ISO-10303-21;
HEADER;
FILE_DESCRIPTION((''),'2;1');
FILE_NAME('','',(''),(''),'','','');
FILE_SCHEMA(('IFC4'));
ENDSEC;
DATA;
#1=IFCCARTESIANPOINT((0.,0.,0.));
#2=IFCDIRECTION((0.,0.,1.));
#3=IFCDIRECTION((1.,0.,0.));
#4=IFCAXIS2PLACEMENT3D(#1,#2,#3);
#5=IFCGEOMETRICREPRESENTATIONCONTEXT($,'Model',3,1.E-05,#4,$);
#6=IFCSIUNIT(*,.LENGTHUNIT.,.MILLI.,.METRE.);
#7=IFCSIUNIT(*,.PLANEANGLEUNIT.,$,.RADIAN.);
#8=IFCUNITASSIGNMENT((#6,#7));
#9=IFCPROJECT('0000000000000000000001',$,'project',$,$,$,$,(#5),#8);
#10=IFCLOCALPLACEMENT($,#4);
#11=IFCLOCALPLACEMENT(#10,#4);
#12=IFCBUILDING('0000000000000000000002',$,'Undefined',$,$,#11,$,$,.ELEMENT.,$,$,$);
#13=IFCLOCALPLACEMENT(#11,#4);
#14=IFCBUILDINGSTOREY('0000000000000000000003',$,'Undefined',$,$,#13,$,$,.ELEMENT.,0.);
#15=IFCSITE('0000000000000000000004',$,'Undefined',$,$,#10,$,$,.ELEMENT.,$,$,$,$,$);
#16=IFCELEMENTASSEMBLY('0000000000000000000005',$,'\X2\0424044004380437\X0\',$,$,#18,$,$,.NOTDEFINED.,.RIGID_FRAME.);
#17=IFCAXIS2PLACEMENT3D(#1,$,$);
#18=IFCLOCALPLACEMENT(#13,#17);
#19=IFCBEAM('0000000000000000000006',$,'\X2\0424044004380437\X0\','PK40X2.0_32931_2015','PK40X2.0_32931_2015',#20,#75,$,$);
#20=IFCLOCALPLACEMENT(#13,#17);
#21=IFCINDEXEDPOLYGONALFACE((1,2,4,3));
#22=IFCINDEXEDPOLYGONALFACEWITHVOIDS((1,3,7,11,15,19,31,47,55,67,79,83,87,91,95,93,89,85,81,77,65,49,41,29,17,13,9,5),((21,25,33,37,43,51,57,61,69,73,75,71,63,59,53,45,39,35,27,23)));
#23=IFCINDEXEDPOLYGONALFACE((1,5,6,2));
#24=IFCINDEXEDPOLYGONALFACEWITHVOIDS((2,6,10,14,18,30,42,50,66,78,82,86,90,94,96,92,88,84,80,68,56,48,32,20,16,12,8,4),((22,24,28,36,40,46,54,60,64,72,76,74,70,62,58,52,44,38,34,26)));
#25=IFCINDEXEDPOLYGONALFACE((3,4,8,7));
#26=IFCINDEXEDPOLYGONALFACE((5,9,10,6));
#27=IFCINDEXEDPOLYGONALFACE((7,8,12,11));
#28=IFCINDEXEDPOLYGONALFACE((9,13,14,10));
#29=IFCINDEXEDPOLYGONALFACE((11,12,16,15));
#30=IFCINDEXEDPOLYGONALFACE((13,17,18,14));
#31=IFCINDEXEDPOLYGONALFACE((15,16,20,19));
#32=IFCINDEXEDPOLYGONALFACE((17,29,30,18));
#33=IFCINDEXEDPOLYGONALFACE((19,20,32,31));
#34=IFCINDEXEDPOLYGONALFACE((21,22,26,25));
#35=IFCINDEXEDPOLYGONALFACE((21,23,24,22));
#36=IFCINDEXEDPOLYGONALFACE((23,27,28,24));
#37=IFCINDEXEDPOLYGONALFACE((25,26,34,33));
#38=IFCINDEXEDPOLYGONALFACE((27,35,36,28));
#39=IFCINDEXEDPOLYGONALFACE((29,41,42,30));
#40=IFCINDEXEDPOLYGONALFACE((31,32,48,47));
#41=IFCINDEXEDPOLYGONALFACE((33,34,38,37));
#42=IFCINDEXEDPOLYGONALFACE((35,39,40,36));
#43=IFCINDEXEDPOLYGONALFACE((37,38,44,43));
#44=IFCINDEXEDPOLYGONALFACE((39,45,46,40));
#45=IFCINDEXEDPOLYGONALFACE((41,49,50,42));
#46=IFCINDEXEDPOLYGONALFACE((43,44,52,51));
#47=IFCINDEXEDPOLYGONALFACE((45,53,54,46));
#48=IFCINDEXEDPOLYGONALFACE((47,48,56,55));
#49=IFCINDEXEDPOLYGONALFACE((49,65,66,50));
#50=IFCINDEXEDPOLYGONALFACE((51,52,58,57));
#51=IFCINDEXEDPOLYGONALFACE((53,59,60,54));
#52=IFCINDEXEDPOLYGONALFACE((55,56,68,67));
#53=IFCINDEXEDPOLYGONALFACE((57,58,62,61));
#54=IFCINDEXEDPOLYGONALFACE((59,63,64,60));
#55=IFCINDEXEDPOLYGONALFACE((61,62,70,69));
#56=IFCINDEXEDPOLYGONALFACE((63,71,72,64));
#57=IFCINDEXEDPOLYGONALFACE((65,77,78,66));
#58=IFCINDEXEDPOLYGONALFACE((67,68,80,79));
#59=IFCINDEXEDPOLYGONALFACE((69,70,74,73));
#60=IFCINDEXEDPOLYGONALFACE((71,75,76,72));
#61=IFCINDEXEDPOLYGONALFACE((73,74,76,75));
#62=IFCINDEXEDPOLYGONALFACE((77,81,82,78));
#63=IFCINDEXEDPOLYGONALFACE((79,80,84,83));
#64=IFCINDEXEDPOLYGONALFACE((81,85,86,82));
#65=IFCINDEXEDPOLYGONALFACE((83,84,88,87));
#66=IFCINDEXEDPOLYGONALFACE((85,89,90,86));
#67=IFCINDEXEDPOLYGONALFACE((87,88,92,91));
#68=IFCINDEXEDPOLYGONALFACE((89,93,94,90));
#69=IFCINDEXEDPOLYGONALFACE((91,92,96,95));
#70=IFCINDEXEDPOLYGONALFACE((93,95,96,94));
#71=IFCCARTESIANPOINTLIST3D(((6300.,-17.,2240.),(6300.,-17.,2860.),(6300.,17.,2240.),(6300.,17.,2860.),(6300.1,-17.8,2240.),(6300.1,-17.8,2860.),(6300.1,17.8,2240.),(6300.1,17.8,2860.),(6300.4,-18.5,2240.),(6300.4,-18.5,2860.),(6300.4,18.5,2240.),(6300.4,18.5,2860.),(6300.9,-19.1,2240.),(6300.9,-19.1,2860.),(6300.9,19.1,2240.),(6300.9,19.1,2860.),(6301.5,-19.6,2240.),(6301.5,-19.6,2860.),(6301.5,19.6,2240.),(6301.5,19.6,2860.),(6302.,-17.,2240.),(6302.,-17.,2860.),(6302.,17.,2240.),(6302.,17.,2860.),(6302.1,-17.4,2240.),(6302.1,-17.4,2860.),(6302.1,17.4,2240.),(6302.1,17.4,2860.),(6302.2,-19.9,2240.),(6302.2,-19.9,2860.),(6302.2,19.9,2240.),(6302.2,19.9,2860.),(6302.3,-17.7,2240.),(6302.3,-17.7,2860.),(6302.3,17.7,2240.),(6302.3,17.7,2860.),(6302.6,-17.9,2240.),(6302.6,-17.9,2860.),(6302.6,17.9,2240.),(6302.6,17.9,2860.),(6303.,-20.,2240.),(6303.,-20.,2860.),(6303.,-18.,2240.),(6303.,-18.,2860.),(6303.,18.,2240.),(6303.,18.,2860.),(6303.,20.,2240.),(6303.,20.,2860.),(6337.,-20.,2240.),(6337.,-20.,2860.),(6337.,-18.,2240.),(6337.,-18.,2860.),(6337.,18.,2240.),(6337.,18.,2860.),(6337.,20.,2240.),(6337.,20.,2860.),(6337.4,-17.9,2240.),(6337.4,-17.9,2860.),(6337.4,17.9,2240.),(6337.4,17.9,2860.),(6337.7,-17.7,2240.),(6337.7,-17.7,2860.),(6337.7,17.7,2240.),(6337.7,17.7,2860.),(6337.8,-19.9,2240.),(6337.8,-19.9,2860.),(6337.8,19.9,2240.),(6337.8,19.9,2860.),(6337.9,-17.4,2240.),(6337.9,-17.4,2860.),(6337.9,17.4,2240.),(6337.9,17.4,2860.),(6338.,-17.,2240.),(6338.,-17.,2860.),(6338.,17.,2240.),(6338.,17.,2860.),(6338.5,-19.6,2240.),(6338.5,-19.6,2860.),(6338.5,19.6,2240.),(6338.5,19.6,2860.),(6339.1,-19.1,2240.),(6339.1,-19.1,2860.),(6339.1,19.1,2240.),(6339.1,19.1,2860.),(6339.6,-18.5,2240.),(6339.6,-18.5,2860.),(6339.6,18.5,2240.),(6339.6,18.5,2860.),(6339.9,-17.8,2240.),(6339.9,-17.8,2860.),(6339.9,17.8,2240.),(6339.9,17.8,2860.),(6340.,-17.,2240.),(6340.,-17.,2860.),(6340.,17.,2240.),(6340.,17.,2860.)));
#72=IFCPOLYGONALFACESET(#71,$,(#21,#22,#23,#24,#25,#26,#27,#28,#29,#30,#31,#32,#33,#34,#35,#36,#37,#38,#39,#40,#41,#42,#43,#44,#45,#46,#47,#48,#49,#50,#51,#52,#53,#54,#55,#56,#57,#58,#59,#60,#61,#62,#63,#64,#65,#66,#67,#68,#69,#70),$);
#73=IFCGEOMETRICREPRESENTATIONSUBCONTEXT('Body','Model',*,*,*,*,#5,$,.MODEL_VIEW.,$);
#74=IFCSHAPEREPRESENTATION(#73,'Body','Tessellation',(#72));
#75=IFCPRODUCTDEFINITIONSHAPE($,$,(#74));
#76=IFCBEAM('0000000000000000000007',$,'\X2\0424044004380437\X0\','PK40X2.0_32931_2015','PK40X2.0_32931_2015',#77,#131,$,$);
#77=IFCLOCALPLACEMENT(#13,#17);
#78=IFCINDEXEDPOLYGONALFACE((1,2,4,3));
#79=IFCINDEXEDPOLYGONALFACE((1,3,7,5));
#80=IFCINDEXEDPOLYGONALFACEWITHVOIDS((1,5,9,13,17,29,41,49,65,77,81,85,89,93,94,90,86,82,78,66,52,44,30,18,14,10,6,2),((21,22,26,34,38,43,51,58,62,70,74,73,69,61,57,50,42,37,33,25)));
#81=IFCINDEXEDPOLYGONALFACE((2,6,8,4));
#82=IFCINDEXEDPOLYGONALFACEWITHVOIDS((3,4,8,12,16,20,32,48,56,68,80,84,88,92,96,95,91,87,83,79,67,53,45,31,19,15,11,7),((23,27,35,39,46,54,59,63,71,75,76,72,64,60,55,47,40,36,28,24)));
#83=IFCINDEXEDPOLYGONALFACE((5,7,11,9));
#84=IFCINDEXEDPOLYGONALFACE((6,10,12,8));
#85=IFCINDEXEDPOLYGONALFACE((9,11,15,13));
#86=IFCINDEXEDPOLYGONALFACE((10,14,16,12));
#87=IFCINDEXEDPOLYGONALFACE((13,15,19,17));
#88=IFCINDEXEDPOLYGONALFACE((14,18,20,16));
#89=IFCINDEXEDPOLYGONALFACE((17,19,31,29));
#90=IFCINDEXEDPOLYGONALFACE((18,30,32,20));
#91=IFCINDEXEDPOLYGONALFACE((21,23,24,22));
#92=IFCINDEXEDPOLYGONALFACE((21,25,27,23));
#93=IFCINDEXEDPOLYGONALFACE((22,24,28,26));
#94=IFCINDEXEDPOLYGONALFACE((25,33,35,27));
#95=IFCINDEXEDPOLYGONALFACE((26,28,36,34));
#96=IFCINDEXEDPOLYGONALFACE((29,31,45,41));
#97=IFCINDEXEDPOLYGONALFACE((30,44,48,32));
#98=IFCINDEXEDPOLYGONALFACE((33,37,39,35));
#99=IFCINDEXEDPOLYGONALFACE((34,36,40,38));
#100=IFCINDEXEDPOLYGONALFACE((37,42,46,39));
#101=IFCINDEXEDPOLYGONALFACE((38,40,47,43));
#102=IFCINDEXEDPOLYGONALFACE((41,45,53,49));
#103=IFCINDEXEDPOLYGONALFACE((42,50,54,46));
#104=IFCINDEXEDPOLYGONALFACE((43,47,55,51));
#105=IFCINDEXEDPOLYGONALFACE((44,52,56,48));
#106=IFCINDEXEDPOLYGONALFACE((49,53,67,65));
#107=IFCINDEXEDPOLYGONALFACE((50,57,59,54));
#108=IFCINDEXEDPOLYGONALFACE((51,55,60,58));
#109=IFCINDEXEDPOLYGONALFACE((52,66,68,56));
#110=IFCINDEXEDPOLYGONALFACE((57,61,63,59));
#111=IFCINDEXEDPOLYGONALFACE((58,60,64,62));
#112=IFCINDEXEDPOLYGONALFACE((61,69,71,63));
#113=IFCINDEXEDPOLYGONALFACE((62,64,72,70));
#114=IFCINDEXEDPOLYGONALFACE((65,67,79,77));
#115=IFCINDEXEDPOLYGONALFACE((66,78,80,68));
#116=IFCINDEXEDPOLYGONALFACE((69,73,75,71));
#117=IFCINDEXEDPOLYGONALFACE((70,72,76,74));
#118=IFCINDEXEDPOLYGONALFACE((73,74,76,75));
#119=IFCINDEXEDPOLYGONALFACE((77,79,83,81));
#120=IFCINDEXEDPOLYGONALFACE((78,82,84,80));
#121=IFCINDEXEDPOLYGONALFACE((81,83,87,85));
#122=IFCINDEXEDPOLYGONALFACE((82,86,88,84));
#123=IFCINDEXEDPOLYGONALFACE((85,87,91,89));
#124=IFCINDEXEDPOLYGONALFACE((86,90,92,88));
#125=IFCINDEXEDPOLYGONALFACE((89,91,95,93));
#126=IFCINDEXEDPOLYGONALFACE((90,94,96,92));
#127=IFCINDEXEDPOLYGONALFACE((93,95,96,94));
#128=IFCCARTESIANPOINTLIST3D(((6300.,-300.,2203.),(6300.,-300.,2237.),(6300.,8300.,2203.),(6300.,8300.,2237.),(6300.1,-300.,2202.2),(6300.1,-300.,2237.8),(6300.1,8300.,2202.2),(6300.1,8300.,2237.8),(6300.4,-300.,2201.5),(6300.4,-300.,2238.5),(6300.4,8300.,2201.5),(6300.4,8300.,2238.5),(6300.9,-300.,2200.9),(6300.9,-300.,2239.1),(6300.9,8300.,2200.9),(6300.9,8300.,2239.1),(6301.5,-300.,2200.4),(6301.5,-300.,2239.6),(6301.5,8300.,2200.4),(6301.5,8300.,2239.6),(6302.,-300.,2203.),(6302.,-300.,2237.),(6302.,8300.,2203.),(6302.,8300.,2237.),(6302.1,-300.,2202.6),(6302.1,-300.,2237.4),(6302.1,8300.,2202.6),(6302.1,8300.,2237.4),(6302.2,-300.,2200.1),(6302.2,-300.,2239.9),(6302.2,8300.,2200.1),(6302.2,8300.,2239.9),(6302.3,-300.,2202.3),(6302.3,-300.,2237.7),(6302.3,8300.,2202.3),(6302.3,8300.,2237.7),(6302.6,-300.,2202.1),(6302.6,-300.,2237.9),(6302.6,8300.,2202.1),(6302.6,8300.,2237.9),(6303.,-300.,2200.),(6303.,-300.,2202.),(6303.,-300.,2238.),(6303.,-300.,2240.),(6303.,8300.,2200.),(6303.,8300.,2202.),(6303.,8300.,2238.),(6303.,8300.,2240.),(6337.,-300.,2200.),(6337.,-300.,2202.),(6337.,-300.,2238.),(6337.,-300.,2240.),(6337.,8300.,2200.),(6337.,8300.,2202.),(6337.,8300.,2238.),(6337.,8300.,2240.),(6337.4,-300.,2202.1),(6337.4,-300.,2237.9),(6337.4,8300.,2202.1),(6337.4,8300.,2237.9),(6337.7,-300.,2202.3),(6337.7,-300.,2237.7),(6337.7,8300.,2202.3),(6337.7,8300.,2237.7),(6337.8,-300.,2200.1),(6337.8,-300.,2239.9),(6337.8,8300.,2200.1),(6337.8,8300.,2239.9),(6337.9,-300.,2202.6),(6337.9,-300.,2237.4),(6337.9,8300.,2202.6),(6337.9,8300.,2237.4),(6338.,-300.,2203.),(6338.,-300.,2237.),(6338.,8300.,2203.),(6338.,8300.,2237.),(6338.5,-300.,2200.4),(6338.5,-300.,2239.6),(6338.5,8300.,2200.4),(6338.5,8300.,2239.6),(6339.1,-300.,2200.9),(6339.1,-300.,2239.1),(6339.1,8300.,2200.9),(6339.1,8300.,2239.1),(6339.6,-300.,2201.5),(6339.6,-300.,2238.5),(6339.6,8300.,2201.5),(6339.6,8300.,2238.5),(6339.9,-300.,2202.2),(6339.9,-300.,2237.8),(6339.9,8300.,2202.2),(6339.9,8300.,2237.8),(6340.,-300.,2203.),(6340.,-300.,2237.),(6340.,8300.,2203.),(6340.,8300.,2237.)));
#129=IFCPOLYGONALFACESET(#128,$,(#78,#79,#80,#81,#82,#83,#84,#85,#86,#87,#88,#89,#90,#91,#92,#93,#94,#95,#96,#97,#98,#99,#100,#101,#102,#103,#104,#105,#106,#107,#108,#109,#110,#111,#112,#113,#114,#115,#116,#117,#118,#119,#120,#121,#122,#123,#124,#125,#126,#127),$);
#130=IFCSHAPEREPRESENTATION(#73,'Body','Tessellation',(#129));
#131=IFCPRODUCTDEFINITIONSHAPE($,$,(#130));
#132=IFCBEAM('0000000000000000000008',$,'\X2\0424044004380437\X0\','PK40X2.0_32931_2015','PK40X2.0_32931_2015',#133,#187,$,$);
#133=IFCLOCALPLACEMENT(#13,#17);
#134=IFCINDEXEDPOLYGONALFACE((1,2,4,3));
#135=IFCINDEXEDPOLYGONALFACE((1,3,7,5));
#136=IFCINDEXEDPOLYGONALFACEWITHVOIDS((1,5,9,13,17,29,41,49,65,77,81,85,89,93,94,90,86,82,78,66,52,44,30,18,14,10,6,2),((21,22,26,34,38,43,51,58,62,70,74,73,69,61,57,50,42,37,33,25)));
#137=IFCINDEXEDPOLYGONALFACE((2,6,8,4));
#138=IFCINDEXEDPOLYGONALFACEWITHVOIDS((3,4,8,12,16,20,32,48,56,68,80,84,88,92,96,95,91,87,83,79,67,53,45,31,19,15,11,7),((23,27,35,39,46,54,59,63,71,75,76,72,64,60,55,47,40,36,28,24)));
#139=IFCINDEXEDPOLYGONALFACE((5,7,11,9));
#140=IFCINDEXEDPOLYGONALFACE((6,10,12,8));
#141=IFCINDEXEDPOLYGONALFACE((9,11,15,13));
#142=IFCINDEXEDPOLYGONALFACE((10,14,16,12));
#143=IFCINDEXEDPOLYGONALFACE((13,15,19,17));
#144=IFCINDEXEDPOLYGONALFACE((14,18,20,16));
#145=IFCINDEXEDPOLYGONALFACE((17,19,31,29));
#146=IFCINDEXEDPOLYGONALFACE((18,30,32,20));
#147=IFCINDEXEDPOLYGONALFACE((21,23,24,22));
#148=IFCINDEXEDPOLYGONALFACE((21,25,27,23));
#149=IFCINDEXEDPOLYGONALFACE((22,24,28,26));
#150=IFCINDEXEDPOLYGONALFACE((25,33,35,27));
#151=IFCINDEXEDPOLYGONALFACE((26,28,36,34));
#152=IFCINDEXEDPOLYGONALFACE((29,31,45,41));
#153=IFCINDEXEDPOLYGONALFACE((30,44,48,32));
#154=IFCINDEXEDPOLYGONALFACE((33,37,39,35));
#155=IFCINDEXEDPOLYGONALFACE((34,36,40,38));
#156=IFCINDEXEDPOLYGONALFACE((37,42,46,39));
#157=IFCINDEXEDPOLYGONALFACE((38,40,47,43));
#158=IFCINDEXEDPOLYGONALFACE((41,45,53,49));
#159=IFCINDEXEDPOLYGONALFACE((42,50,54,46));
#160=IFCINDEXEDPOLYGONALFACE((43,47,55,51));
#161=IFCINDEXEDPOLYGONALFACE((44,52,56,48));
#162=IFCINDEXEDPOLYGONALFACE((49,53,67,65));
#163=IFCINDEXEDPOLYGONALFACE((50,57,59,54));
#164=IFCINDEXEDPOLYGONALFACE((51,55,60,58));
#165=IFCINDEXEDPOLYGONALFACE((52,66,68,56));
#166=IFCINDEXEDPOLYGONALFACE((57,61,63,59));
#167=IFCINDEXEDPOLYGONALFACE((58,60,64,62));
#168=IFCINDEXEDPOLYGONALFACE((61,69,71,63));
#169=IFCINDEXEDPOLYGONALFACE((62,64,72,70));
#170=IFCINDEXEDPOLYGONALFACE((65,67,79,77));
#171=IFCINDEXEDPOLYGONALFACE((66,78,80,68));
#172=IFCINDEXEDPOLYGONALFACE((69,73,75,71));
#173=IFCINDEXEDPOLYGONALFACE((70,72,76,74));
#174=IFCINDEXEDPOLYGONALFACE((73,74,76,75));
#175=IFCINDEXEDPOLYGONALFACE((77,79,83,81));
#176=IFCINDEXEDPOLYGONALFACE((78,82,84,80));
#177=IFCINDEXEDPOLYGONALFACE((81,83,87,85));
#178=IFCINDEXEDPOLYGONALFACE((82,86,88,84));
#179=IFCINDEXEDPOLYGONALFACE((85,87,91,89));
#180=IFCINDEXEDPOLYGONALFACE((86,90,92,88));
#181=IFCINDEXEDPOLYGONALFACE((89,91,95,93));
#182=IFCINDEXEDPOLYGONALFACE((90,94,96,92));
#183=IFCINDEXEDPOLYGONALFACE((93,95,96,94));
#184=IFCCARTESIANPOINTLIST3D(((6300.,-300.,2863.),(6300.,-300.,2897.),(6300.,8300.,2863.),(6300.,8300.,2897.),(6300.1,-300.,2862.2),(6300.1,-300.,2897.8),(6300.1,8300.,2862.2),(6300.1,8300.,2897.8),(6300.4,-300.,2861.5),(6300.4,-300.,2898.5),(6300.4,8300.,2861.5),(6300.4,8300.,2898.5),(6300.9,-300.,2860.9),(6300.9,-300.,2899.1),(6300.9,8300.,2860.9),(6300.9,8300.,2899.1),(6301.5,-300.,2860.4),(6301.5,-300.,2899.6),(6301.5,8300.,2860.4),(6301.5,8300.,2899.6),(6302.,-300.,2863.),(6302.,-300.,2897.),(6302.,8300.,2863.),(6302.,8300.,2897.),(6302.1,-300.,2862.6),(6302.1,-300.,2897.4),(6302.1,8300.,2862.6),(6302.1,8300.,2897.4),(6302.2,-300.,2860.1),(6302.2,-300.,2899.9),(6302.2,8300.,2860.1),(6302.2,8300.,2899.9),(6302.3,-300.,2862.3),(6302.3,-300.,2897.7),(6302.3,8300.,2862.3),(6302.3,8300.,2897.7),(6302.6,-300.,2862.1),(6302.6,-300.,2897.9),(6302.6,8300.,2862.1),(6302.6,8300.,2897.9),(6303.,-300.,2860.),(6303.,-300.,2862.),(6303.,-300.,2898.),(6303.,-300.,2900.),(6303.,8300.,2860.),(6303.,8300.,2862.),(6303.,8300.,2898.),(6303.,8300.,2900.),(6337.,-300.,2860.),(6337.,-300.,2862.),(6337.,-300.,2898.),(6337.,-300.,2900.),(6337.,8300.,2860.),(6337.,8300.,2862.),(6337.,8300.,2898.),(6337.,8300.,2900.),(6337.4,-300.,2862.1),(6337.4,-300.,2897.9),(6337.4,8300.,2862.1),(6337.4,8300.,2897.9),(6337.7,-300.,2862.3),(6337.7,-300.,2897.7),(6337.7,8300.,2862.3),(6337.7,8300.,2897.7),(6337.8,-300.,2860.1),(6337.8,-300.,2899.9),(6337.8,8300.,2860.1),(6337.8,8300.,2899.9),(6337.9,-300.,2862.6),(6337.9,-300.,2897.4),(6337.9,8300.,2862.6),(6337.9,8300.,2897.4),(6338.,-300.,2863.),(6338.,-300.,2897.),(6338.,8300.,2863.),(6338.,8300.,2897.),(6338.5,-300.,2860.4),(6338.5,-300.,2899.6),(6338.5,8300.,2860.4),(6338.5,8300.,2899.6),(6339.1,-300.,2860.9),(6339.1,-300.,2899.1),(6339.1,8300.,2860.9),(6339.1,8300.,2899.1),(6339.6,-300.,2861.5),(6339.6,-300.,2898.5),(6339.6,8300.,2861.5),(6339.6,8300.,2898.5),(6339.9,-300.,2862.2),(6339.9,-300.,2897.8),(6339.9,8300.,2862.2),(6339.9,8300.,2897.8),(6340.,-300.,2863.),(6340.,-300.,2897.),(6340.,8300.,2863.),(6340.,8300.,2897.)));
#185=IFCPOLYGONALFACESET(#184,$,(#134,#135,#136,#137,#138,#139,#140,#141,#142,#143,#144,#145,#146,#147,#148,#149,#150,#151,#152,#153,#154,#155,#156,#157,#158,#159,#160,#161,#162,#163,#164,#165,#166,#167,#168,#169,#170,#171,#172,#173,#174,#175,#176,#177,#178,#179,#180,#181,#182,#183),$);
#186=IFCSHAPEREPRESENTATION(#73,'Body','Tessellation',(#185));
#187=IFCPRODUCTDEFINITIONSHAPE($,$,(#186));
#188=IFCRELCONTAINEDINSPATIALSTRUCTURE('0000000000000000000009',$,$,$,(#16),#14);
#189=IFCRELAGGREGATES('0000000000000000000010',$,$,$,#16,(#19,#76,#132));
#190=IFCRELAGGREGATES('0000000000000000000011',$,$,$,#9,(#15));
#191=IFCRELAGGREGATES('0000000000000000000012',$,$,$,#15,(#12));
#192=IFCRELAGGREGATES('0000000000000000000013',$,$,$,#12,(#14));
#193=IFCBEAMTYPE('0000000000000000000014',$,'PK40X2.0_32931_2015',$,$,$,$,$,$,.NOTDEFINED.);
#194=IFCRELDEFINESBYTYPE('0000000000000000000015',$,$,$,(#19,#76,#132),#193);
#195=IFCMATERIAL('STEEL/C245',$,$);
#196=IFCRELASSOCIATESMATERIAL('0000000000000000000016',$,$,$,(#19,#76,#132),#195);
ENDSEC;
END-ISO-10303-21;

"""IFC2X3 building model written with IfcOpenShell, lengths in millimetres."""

from ifc_helpers import new_model, si_unit, frame, origin_with_axes, origin_2d_with_axis, place, context, subcontext, project, spatial, hollow_rectangle, extrude, material, type_object, element, aggregate, save


model = new_model("IFC2X3")

# Units and contexts
model_context = context("Model", 3, precision=1e-05, world=origin_with_axes())
body_context = subcontext(model_context, "Body", "Model", "MODEL_VIEW")
ifc_project = project(units=[si_unit("LENGTHUNIT", "METRE", prefix="MILLI"), si_unit("PLANEANGLEUNIT", "RADIAN")], contexts=[model_context])

# Site, building, storey
site_placement = place(None, origin_with_axes())
site = spatial("IfcSite", under=ifc_project, at=site_placement, Name="Undefined", CompositionType="ELEMENT")
building_placement = place(site_placement, origin_with_axes())
building = spatial("IfcBuilding", under=site, at=building_placement, Name="Undefined", CompositionType="ELEMENT")
storey_placement = place(building_placement, origin_with_axes())
storey = spatial("IfcBuildingStorey", under=building, at=storey_placement, Name="Undefined", CompositionType="ELEMENT", Elevation=0.0)

# Shared definitions
ifc_material_1 = material(Name="STEEL/C245")

# Shared definitions
beam_type_1 = type_object("IfcBeamType", Name="PK40X2.0_32931_2015", PredefinedType="NOTDEFINED")

# Element assembly, beams
assembly_1_placement = place(storey_placement, origin_with_axes())
assembly_1 = element("IfcElementAssembly", 1, at=assembly_1_placement, inside=storey, Name="Фриз", AssemblyPlace="NOTDEFINED", PredefinedType="RIGID_FRAME")
beam_1_placement = place(assembly_1_placement, frame((6320.0, 0.0, 2860.0), z_axis=(-1.0, 0.0, 0.0), x_axis=(0.0, 0.0, -1.0)))
beam_1 = element("IfcBeam", 2, at=beam_1_placement, type_object=beam_type_1, material=ifc_material_1, Name="Фриз", Description="PK40X2.0_32931_2015", ObjectType="PK40X2.0_32931_2015", context=body_context, shape_type="SweptSolid", body=[
    extrude(hollow_rectangle(XDim=40.0, YDim=40.0, WallThickness=2.0, InnerFilletRadius=1.0, OuterFilletRadius=3.0, at=origin_2d_with_axis()), frame((620.0, 0.0, 0.0), z_axis=(-1.0, 0.0, 0.0), x_axis=(0.0, -1.0, 0.0)), (0.0, 0.0, 1.0), 620.0),
])
beam_2_placement = place(assembly_1_placement, frame((6320.0, -300.0, 2220.0), z_axis=(0.0, 0.0, 1.0), x_axis=(0.0, 1.0, 0.0)))
beam_2 = element("IfcBeam", 3, at=beam_2_placement, type_object=beam_type_1, material=ifc_material_1, Name="Фриз", Description="PK40X2.0_32931_2015", ObjectType="PK40X2.0_32931_2015", context=body_context, shape_type="SweptSolid", body=[
    extrude(hollow_rectangle(XDim=40.0, YDim=40.0, WallThickness=2.0, InnerFilletRadius=1.0, OuterFilletRadius=3.0, at=origin_2d_with_axis()), frame((8600.0, 0.0, 0.0), z_axis=(-1.0, 0.0, 0.0), x_axis=(0.0, -1.0, 0.0)), (0.0, 0.0, 1.0), 8600.0),
])
beam_3_placement = place(assembly_1_placement, frame((6320.0, -300.0, 2880.0), z_axis=(0.0, 0.0, 1.0), x_axis=(0.0, 1.0, 0.0)))
beam_3 = element("IfcBeam", 4, at=beam_3_placement, type_object=beam_type_1, material=ifc_material_1, Name="Фриз", Description="PK40X2.0_32931_2015", ObjectType="PK40X2.0_32931_2015", context=body_context, shape_type="SweptSolid", body=[
    extrude(hollow_rectangle(XDim=40.0, YDim=40.0, WallThickness=2.0, InnerFilletRadius=1.0, OuterFilletRadius=3.0, at=origin_2d_with_axis()), frame((8600.0, 0.0, 0.0), z_axis=(-1.0, 0.0, 0.0), x_axis=(0.0, -1.0, 0.0)), (0.0, 0.0, 1.0), 8600.0),
])
aggregate(assembly_1, [beam_1, beam_2, beam_3])

save(model, "model.ifc")
